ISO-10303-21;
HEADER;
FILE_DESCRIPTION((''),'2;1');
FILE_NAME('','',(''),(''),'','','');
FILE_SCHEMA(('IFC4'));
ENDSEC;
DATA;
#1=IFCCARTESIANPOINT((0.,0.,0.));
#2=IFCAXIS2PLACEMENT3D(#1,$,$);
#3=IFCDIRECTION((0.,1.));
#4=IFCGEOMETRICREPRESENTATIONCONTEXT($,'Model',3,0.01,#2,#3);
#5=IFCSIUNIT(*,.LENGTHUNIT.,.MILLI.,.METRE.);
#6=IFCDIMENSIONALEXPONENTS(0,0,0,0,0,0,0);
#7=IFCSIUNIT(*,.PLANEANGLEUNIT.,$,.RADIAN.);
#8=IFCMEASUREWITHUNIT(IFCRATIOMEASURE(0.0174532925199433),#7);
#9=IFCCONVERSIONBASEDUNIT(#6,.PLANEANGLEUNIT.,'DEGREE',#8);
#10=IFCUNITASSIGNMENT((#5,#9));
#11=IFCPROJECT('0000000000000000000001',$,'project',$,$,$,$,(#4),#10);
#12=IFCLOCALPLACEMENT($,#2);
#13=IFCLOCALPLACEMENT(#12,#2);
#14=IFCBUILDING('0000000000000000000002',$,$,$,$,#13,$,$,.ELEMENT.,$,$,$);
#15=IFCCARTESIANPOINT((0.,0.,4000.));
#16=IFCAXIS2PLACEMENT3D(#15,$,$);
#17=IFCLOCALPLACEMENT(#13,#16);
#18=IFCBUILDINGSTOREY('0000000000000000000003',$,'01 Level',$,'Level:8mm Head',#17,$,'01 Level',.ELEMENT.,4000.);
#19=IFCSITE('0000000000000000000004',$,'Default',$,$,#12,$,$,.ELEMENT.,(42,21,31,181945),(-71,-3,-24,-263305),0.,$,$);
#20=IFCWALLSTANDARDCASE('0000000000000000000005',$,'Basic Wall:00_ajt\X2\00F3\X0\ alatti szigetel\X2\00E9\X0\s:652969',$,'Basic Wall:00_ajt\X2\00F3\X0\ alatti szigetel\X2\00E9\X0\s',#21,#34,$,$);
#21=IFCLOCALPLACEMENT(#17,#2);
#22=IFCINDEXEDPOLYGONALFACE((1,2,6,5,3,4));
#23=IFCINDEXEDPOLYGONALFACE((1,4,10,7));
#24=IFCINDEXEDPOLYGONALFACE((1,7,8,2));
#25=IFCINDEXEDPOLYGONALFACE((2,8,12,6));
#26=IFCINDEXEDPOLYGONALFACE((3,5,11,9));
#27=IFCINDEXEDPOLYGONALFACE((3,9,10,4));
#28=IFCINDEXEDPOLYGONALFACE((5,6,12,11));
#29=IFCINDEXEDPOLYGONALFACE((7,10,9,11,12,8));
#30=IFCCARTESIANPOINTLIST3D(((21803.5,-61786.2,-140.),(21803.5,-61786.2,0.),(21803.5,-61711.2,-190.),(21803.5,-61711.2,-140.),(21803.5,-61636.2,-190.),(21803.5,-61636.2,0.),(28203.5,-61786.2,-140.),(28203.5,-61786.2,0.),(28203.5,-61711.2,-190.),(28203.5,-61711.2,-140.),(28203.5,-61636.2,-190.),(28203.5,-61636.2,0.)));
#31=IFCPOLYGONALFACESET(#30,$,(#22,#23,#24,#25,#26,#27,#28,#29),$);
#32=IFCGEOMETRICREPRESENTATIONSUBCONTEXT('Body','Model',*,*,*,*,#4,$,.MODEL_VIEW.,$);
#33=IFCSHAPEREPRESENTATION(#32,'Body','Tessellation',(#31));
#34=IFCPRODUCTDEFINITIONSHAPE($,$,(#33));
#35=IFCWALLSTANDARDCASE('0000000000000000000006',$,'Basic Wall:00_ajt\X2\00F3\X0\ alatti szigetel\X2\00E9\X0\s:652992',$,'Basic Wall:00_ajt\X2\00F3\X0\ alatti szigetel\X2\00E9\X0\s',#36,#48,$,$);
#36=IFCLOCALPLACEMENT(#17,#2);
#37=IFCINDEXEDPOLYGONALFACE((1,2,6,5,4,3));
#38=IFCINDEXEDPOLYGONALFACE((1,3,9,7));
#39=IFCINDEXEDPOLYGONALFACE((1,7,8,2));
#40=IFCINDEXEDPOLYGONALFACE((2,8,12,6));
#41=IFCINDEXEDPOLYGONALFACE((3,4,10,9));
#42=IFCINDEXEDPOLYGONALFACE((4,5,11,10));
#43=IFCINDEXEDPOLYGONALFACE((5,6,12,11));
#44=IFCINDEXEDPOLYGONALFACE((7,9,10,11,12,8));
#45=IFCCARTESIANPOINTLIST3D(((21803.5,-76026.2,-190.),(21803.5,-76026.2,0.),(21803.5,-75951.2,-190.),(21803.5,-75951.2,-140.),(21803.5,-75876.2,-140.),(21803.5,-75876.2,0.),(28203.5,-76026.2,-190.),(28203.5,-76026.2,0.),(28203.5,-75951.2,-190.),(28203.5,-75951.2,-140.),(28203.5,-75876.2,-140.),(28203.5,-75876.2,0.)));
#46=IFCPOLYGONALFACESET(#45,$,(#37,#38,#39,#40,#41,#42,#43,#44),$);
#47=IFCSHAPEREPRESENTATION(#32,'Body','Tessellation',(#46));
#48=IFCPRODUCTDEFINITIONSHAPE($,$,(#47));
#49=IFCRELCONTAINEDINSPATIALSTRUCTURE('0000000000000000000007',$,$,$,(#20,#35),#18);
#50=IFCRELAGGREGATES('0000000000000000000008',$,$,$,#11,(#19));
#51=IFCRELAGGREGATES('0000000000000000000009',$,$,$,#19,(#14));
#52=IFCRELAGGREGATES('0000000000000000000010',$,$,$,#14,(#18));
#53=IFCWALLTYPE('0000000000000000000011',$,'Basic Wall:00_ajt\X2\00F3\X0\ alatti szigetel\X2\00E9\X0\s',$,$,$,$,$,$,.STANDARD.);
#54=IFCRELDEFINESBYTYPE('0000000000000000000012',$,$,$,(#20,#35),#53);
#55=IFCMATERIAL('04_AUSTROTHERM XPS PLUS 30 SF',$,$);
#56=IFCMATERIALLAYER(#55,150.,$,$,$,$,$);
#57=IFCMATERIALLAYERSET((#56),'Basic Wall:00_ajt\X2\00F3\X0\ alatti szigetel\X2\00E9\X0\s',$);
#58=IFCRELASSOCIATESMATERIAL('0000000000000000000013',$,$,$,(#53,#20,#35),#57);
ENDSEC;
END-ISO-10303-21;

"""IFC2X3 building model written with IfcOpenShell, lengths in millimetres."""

from ifc_helpers import new_model, entity, si_unit, converted_unit, direction, frame, frame_2d, origin, place, context, subcontext, project, spatial, polyline, rectangle, extrude, clip, bounded_halfspace, material, layer, layer_set, layer_usage, type_object, element, save


model = new_model("IFC2X3")

# Units and contexts
model_context = context("Model", 3, precision=0.01, world=origin(), true_north=direction((0.0, 1.0)))
body_context = subcontext(model_context, "Body", "Model", "MODEL_VIEW")
ifc_project = project(units=[si_unit("LENGTHUNIT", "METRE", prefix="MILLI"), converted_unit("PLANEANGLEUNIT", "DEGREE", entity("IfcRatioMeasure", 0.0174532925199433), si_unit("PLANEANGLEUNIT", "RADIAN"), dimensions=[0, 0, 0, 0, 0, 0, 0])], contexts=[model_context])

# Site, building, storey
site_placement = place(None, origin())
site = spatial("IfcSite", under=ifc_project, at=site_placement, Name="Default", CompositionType="ELEMENT", RefLatitude=(42, 21, 31, 181945), RefLongitude=(-71, -3, -24, -263305), RefElevation=0.0)
building_placement = place(site_placement, origin())
building = spatial("IfcBuilding", under=site, at=building_placement, CompositionType="ELEMENT")
storey_placement = place(building_placement, frame((0.0, 0.0, 4000.0)))
storey = spatial("IfcBuildingStorey", under=building, at=storey_placement, Name="01 Level", ObjectType="Level:8mm Head", LongName="01 Level", CompositionType="ELEMENT", Elevation=4000.0)

# Walls
ifc_material = material(Name="04_AUSTROTHERM XPS PLUS 30 SF")
ifc_layer = layer(ifc_material, 150.0)
ifc_layer_set = layer_set([ifc_layer], Name="Basic Wall:00_ajtó alatti szigetelés")
ifc_layer_usage_1 = layer_usage(ifc_layer_set, "AXIS2", "POSITIVE", -75.0)
wall_type = type_object("IfcWallType", Name="Basic Wall:00_ajtó alatti szigetelés", PredefinedType="STANDARD", material=ifc_layer_set)
wall_1_placement = place(storey_placement, frame((28203.5, -61711.2, -190.0), z_axis=(0.0, 0.0, 1.0), x_axis=(-1.0, 0.0, 0.0)))
element("IfcWallStandardCase", 1, at=wall_1_placement, inside=storey, type_object=wall_type, material=ifc_layer_usage_1, Name="Basic Wall:00_ajtó alatti szigetelés:652969", ObjectType="Basic Wall:00_ajtó alatti szigetelés", context=body_context, shape_type="Clipping", body=[
    clip(clip(extrude(rectangle(XDim=6400.0, YDim=150.0, at=frame_2d((3200.0, 0.0), x_axis=(-1.0, 0.0))), origin(), (0.0, 0.0, 1.0), 190.0), bounded_halfspace(frame((6400.0, 0.0, 50.0)), True, frame((6400.0, 0.0, 50.0)), polyline([(0.0, 0.0), (0.0, 75.0), (-6400.0, 75.0), (-6400.0, 0.0), (0.0, 0.0)]))), bounded_halfspace(frame((0.0, 0.0, 50.0), z_axis=(0.0, -1.0, 0.0), x_axis=(0.0, 0.0, 1.0)), True, frame((0.0, 0.0, 50.0), z_axis=(0.0, -1.0, 0.0), x_axis=(0.0, 0.0, 1.0)), polyline([(0.0, 0.0), (-50.0, 0.0), (-50.0, -6400.0), (0.0, -6400.0), (0.0, 0.0)]))),
])
ifc_layer_usage_2 = layer_usage(ifc_layer_set, "AXIS2", "NEGATIVE", 75.0)
wall_2_placement = place(storey_placement, frame((28203.5, -75951.2, -190.0), z_axis=(0.0, 0.0, 1.0), x_axis=(-1.0, 0.0, 0.0)))
element("IfcWallStandardCase", 2, at=wall_2_placement, inside=storey, type_object=wall_type, material=ifc_layer_usage_2, Name="Basic Wall:00_ajtó alatti szigetelés:652992", ObjectType="Basic Wall:00_ajtó alatti szigetelés", context=body_context, shape_type="Clipping", body=[
    clip(clip(extrude(rectangle(XDim=6400.0, YDim=150.0, at=frame_2d((3200.0, 0.0), x_axis=(-1.0, 0.0))), origin(), (0.0, 0.0, 1.0), 190.0), bounded_halfspace(frame((0.0, 0.0, 50.0)), True, frame((0.0, 0.0, 50.0)), polyline([(0.0, 0.0), (0.0, -75.0), (6400.0, -75.0), (6400.0, 0.0), (0.0, 0.0)]))), bounded_halfspace(frame((6400.0, 0.0, 50.0), z_axis=(0.0, 1.0, 0.0), x_axis=(0.0, 0.0, 1.0)), True, frame((6400.0, 0.0, 50.0), z_axis=(0.0, 1.0, 0.0), x_axis=(0.0, 0.0, 1.0)), polyline([(0.0, 0.0), (-50.0, 0.0), (-50.0, -6400.0), (0.0, -6400.0), (0.0, 0.0)]))),
])

save(model, "model.ifc")
